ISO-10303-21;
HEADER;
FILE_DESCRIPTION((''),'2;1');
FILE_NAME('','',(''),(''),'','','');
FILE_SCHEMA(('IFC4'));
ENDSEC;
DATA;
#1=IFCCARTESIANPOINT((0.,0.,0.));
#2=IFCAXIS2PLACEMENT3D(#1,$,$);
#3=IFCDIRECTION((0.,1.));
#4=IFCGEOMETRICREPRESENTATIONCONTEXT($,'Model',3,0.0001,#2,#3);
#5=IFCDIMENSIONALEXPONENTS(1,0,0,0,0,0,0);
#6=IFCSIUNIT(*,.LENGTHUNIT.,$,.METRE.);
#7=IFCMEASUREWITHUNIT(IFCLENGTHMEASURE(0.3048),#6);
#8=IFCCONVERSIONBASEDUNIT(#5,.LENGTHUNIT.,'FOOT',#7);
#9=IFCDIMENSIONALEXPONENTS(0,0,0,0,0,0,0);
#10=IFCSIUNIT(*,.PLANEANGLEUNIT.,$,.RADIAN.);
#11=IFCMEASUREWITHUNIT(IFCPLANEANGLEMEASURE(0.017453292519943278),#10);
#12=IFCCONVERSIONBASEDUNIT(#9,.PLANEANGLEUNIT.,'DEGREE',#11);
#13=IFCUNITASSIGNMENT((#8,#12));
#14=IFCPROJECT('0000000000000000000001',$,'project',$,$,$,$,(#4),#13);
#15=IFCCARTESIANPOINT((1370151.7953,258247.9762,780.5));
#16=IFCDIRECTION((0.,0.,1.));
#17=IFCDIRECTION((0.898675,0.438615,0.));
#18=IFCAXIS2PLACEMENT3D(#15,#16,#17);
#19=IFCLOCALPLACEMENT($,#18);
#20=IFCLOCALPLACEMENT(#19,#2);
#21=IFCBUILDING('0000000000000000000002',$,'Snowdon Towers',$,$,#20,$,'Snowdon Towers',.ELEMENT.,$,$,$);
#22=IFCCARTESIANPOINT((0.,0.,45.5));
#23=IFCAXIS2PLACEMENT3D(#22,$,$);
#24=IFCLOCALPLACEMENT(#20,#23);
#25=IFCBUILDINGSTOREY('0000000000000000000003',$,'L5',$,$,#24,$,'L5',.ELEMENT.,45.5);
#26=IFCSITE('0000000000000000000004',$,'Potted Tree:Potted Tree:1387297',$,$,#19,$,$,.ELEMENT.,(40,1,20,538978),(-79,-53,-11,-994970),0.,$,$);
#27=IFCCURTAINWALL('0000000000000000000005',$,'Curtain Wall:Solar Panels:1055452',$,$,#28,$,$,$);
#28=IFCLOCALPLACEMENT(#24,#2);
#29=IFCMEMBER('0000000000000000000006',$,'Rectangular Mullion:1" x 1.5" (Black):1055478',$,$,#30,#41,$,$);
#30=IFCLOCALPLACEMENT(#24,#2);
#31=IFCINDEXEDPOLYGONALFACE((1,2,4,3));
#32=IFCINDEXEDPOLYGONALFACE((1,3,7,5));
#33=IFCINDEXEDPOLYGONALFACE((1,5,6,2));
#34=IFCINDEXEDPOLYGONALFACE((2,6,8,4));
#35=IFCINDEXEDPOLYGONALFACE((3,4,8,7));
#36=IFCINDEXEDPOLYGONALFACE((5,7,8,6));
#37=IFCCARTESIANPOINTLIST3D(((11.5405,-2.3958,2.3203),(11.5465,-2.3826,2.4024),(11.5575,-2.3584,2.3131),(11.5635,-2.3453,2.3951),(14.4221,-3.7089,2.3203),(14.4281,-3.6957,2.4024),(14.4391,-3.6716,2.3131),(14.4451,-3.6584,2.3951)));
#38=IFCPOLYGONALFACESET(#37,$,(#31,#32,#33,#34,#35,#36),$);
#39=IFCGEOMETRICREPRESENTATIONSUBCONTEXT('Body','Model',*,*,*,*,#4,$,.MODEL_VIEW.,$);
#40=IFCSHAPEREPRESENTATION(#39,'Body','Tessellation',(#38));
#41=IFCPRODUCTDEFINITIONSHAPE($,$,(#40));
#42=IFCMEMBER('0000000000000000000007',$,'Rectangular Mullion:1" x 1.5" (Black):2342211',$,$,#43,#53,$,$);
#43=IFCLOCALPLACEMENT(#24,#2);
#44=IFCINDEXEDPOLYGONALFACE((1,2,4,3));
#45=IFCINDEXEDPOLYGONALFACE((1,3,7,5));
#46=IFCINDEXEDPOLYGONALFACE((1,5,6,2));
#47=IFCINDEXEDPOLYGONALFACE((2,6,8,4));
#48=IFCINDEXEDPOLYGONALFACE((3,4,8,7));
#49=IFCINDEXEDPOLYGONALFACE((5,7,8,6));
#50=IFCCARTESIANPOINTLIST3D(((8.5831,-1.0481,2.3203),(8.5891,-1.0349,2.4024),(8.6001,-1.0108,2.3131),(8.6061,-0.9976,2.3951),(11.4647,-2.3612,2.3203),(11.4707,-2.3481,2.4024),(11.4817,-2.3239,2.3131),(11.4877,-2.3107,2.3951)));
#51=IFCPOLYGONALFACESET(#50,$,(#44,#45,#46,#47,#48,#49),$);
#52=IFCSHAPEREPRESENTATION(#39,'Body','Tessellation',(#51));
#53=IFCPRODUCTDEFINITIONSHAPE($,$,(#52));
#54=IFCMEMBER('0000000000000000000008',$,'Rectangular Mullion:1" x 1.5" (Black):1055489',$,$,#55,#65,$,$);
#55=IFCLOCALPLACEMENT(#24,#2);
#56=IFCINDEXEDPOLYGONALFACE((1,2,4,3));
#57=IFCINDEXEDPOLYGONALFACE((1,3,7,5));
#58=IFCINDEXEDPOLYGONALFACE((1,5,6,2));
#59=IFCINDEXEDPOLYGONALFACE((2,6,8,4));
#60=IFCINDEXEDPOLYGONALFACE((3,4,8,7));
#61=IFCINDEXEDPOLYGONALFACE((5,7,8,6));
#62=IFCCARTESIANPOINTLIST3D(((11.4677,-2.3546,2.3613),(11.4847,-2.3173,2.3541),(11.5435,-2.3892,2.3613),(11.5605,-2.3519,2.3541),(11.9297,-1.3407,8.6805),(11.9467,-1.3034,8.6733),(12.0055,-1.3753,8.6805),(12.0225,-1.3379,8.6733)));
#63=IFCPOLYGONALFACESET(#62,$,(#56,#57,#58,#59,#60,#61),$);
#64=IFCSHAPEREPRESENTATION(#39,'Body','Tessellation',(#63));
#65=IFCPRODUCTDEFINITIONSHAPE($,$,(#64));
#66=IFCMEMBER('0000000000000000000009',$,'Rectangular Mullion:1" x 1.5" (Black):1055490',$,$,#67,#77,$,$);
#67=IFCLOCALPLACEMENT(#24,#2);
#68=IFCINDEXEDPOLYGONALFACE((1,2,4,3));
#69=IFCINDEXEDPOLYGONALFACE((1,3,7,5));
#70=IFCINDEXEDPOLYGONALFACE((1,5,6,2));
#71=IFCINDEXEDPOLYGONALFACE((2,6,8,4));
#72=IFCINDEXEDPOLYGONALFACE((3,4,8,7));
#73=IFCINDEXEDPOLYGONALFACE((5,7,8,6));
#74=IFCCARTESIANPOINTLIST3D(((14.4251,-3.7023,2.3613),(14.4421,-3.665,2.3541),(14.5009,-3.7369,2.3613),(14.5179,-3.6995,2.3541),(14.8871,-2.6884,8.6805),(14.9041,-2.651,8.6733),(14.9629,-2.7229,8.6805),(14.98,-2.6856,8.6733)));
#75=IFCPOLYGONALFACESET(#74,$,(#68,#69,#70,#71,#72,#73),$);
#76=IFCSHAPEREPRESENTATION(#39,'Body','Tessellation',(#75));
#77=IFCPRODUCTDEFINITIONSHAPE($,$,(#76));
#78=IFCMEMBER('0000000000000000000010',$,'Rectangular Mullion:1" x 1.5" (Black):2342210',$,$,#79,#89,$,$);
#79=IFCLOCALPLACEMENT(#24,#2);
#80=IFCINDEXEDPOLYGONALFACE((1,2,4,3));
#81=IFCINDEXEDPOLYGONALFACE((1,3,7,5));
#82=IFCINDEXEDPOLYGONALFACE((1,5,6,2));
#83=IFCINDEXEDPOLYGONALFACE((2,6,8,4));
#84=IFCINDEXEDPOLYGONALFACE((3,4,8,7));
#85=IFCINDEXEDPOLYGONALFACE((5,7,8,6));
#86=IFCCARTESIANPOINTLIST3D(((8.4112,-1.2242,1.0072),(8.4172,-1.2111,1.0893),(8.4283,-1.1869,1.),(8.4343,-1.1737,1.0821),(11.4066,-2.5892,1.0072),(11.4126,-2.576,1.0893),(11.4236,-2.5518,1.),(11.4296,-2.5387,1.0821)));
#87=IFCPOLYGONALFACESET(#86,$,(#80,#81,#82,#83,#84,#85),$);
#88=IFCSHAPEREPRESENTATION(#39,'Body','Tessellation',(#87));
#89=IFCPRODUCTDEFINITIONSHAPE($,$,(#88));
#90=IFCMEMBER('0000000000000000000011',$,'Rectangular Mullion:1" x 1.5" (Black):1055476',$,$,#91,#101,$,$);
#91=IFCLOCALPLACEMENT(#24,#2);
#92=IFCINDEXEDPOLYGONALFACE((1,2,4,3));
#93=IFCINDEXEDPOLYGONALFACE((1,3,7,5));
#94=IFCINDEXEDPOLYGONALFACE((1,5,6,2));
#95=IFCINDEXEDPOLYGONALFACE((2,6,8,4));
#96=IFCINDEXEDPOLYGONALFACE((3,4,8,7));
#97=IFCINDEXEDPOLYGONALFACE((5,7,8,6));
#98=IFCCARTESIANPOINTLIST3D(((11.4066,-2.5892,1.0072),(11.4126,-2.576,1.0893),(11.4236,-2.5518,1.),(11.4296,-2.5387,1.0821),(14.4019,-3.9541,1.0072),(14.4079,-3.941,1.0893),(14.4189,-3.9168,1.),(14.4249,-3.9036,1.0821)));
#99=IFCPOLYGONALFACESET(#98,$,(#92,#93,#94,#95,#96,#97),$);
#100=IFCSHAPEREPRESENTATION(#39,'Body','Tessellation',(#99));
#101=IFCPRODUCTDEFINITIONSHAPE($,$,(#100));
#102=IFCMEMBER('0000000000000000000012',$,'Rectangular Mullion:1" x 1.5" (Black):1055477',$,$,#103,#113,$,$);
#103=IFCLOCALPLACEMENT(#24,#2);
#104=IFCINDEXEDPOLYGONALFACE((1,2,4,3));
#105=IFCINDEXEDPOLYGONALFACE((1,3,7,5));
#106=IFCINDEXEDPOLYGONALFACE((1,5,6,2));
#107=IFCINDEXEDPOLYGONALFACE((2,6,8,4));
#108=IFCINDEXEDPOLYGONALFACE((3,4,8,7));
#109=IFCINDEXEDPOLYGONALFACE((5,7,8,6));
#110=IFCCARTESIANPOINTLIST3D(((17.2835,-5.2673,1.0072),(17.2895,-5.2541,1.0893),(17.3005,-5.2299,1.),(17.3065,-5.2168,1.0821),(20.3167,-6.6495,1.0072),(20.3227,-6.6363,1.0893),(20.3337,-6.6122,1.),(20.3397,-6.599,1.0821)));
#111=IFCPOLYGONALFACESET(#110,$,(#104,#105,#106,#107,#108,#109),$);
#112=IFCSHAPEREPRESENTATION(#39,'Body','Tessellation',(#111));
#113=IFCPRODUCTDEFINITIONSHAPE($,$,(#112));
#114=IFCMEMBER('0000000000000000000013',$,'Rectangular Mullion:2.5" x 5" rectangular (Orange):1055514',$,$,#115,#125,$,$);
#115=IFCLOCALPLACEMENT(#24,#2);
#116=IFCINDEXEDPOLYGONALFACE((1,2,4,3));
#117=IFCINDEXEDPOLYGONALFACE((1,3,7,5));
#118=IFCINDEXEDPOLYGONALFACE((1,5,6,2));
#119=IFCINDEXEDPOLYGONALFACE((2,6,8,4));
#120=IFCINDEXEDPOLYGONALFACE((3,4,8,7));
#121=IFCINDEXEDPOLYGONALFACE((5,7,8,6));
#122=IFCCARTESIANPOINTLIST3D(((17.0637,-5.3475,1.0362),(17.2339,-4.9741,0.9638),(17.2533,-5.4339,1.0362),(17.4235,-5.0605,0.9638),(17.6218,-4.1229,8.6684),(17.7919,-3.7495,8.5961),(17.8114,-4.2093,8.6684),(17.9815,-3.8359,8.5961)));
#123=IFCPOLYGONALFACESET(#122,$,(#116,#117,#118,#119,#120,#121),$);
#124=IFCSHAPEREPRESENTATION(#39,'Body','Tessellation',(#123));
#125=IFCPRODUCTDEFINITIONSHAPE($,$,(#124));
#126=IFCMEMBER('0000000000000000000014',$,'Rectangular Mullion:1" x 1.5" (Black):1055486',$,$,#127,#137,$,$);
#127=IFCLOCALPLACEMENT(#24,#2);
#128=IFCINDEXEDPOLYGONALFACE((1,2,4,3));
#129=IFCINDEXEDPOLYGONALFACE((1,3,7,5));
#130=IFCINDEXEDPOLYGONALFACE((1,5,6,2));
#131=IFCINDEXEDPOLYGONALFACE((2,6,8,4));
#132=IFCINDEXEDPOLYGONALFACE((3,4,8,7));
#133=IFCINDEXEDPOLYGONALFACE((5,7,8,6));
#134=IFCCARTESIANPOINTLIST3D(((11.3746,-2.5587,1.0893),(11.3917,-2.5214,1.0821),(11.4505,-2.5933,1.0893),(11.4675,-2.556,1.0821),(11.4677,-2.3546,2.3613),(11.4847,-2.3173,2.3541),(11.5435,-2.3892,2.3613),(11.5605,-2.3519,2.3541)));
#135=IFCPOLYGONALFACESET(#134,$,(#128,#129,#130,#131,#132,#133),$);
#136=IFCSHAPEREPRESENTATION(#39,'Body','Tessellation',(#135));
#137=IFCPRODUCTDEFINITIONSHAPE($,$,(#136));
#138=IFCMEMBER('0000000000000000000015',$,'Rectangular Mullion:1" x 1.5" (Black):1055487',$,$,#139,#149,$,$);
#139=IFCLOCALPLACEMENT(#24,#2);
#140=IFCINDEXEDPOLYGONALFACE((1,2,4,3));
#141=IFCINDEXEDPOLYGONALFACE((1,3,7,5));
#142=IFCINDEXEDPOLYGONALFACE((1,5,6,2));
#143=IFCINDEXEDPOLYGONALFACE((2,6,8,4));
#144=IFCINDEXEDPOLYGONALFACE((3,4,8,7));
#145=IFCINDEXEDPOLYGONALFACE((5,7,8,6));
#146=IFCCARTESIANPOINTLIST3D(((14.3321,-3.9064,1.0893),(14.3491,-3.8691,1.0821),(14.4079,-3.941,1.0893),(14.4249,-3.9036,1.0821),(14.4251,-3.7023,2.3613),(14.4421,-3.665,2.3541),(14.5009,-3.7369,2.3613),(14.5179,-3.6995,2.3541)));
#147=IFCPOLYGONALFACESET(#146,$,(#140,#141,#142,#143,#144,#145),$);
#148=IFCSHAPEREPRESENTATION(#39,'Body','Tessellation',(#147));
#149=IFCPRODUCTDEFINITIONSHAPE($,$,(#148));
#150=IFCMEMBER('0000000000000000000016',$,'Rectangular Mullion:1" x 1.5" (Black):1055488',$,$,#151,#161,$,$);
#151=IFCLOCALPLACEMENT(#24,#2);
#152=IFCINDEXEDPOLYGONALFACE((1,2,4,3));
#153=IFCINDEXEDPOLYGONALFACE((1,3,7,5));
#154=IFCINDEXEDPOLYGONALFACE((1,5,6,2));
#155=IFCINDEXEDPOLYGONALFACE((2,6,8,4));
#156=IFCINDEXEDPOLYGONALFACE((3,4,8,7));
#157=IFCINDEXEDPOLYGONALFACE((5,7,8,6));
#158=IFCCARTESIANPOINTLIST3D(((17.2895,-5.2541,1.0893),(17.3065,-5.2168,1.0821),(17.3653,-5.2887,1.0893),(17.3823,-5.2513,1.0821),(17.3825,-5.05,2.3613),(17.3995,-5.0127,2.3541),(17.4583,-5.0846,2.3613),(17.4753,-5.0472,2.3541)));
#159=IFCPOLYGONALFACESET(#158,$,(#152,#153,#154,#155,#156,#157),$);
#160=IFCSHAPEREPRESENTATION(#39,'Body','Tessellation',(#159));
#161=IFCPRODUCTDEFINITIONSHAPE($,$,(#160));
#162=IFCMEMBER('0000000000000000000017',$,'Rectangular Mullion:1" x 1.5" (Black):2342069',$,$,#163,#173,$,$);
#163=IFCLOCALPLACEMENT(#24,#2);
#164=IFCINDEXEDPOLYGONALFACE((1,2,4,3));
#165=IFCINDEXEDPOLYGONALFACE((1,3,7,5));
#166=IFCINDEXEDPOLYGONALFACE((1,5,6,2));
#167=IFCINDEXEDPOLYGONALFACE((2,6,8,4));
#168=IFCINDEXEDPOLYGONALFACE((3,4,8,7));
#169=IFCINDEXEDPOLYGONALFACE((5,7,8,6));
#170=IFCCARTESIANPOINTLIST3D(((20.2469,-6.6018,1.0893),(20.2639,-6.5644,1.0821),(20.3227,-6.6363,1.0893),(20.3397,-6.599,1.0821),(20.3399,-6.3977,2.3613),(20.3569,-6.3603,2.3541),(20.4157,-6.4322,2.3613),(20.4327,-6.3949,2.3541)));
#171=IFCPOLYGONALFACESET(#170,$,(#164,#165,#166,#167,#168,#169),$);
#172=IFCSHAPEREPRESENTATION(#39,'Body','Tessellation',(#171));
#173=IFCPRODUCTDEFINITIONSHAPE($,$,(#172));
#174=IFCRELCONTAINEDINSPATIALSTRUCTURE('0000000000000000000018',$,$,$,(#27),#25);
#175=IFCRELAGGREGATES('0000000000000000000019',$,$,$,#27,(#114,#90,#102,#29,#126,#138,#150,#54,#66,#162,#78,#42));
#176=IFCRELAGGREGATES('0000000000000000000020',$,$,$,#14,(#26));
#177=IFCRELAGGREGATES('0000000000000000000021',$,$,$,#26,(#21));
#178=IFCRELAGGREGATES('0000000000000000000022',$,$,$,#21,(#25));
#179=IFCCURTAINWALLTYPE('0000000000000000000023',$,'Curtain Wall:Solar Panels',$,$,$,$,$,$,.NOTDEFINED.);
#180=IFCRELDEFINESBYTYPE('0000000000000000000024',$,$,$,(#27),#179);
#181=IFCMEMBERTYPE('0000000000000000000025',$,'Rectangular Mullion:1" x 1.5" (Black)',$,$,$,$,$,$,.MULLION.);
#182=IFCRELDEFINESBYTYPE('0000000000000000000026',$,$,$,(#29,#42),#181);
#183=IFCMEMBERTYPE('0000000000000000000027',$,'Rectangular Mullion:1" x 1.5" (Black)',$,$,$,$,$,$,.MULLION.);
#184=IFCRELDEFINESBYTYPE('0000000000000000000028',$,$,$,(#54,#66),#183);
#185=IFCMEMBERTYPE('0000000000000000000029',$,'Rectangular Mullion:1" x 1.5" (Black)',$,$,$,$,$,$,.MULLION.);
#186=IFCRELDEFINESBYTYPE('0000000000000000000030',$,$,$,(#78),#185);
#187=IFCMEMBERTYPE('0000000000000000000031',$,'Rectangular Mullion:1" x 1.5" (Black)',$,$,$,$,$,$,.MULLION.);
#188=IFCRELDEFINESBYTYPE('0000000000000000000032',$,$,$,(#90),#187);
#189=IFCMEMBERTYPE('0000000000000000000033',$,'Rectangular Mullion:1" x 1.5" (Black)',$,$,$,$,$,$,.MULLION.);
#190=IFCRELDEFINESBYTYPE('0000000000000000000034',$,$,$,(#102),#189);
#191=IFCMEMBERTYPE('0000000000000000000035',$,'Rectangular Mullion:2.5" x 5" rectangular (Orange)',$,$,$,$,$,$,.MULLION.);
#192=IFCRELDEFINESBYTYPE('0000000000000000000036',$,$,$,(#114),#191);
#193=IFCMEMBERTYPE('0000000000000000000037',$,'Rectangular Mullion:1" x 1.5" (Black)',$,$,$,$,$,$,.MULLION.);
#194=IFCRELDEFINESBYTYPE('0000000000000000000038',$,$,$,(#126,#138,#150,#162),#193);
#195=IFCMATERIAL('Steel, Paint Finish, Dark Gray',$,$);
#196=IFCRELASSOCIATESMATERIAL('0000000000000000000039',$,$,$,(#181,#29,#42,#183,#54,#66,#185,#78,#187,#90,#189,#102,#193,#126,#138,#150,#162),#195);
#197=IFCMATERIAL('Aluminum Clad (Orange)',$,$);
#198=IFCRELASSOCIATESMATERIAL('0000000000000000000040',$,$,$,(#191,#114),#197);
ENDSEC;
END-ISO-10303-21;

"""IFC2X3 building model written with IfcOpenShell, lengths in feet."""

from ifc_helpers import new_model, entity, si_unit, converted_unit, direction, frame, frame_2d, origin, origin_2d_with_axis, place, context, subcontext, project, spatial, rectangle, extrude, source, transform, mapped, material, type_object, type_shapes, element, aggregate, save


model = new_model("IFC2X3")

# Units and contexts
model_context = context("Model", 3, precision=0.0001, world=origin(), true_north=direction((0.0, 1.0)))
body_context = subcontext(model_context, "Body", "Model", "MODEL_VIEW")
ifc_project = project(units=[converted_unit("LENGTHUNIT", "FOOT", entity("IfcLengthMeasure", 0.3048), si_unit("LENGTHUNIT", "METRE"), dimensions=[1, 0, 0, 0, 0, 0, 0]), converted_unit("PLANEANGLEUNIT", "DEGREE", entity("IfcPlaneAngleMeasure", 0.017453292519943278), si_unit("PLANEANGLEUNIT", "RADIAN"), dimensions=[0, 0, 0, 0, 0, 0, 0])], contexts=[model_context])

# Site, building, storey
site_placement = place(None, frame((1370151.7953, 258247.9762, 780.5), z_axis=(0.0, 0.0, 1.0), x_axis=(0.898675, 0.438615, 0.0)))
site = spatial("IfcSite", under=ifc_project, at=site_placement, Name="Potted Tree:Potted Tree:1387297", CompositionType="ELEMENT", RefLatitude=(40, 1, 20, 538978), RefLongitude=(-79, -53, -11, -994970), RefElevation=0.0)
building_placement = place(site_placement, origin())
building = spatial("IfcBuilding", under=site, at=building_placement, Name="Snowdon Towers", LongName="Snowdon Towers", CompositionType="ELEMENT")
storey_placement = place(building_placement, frame((0.0, 0.0, 45.5)))
storey = spatial("IfcBuildingStorey", under=building, at=storey_placement, Name="L5", LongName="L5", CompositionType="ELEMENT", Elevation=45.5)

# Curtain wall, members
curtain_wall_type_1 = type_object("IfcCurtainWallType", Name="Curtain Wall:Solar Panels", PredefinedType="NOTDEFINED")
curtain_wall_1_placement = place(storey_placement, frame((0.0, 0.0, -45.5)))
curtain_wall_1 = element("IfcCurtainWall", 1, at=curtain_wall_1_placement, inside=storey, type_object=curtain_wall_type_1, Name="Curtain Wall:Solar Panels:1055452")
ifc_material_1 = material(Name="Steel, Paint Finish, Dark Gray")
member_type_1 = type_object("IfcMemberType", Name="Rectangular Mullion:1\" x 1.5\" (Black)", PredefinedType="MULLION", material=ifc_material_1)
shared_shape_1 = source(origin(), body_context, "Body", "SweptSolid", [
    extrude(rectangle(XDim=0.0833, YDim=0.0417, at=origin_2d_with_axis()), frame((0.0, 0.0208, -3.1667), z_axis=(0.0, 0.0, 1.0), x_axis=(-1.0, 0.0, 0.0)), (0.0, 0.0, 1.0), 3.1667),
])
type_shapes(member_type_1, [shared_shape_1])
member_1_placement = place(curtain_wall_1_placement, frame((14.4421, -3.665, 47.8541), z_axis=(0.909972, -0.414671, 0.0), x_axis=(0.072007, 0.158015, 0.984808)))
member_1 = element("IfcMember", 2, at=member_1_placement, type_object=member_type_1, material=ifc_material_1, Name="Rectangular Mullion:1\" x 1.5\" (Black):1055478", context=body_context, shape_type="MappedRepresentation", body=[
    mapped(shared_shape_1, transform((0.0, 0.0, 0.0), scale=1.0)),
])
member_2_placement = place(curtain_wall_1_placement, frame((11.4847, -2.3173, 47.8541), z_axis=(0.909972, -0.414671, 0.0), x_axis=(0.072007, 0.158015, 0.984808)))
member_2 = element("IfcMember", 3, at=member_2_placement, type_object=member_type_1, material=ifc_material_1, Name="Rectangular Mullion:1\" x 1.5\" (Black):2342211", context=body_context, shape_type="MappedRepresentation", body=[
    mapped(shared_shape_1, transform((0.0, 0.0, 0.0), scale=1.0)),
])
member_type_2 = type_object("IfcMemberType", Name="Rectangular Mullion:1\" x 1.5\" (Black)", PredefinedType="MULLION", material=ifc_material_1)
shared_shape_2 = source(origin(), body_context, "Body", "SweptSolid", [
    extrude(rectangle(XDim=0.0833, YDim=0.0417, at=origin_2d_with_axis()), frame((0.0, 0.0208, -6.4167), z_axis=(0.0, 0.0, 1.0), x_axis=(-1.0, 0.0, 0.0)), (0.0, 0.0, 1.0), 6.4167),
])
type_shapes(member_type_2, [shared_shape_2])
member_3_placement = place(curtain_wall_1_placement, frame((11.5226, -2.3346, 47.8541), z_axis=(-0.072007, -0.158015, -0.984808), x_axis=(0.909972, -0.414671, 0.0)))
member_3 = element("IfcMember", 4, at=member_3_placement, type_object=member_type_2, material=ifc_material_1, Name="Rectangular Mullion:1\" x 1.5\" (Black):1055489", context=body_context, shape_type="MappedRepresentation", body=[
    mapped(shared_shape_2, transform((0.0, 0.0, 0.0), scale=1.0)),
])
member_4_placement = place(curtain_wall_1_placement, frame((14.48, -3.6823, 47.8541), z_axis=(-0.072007, -0.158015, -0.984808), x_axis=(0.909972, -0.414671, 0.0)))
member_4 = element("IfcMember", 5, at=member_4_placement, type_object=member_type_2, material=ifc_material_1, Name="Rectangular Mullion:1\" x 1.5\" (Black):1055490", context=body_context, shape_type="MappedRepresentation", body=[
    mapped(shared_shape_2, transform((0.0, 0.0, 0.0), scale=1.0)),
])
member_type_3 = type_object("IfcMemberType", Name="Rectangular Mullion:1\" x 1.5\" (Black)", PredefinedType="MULLION", material=ifc_material_1)
shared_shape_3 = source(origin(), body_context, "Body", "SweptSolid", [
    extrude(rectangle(XDim=0.0833, YDim=0.0417, at=origin_2d_with_axis()), frame((-0.0417, 0.0208, -3.2917), z_axis=(0.0, 0.0, 1.0), x_axis=(-1.0, 0.0, 0.0)), (0.0, 0.0, 1.0), 3.2917),
])
type_shapes(member_type_3, [shared_shape_3])
member_5_placement = place(curtain_wall_1_placement, frame((8.4283, -1.1869, 46.5), z_axis=(-0.909972, 0.414671, 0.0), x_axis=(-0.072007, -0.158015, -0.984808)))
member_5 = element("IfcMember", 6, at=member_5_placement, type_object=member_type_3, material=ifc_material_1, Name="Rectangular Mullion:1\" x 1.5\" (Black):2342210", context=body_context, shape_type="MappedRepresentation", body=[
    mapped(shared_shape_3, transform((0.0, 0.0, 0.0), scale=1.0)),
])
member_type_4 = type_object("IfcMemberType", Name="Rectangular Mullion:1\" x 1.5\" (Black)", PredefinedType="MULLION", material=ifc_material_1)
shared_shape_4 = source(origin(), body_context, "Body", "SweptSolid", [
    extrude(rectangle(XDim=0.0833, YDim=0.0417, at=frame_2d((0.0, 0.0), x_axis=(1.0, 0.0))), frame((-0.0417, 0.0208, -3.2917), z_axis=(0.0, 0.0, 1.0), x_axis=(-1.0, 0.0, 0.0)), (0.0, 0.0, 1.0), 3.2917),
])
type_shapes(member_type_4, [shared_shape_4])
member_6_placement = place(curtain_wall_1_placement, frame((11.4236, -2.5518, 46.5), z_axis=(-0.909972, 0.414671, 0.0), x_axis=(-0.072007, -0.158015, -0.984808)))
member_6 = element("IfcMember", 7, at=member_6_placement, type_object=member_type_4, material=ifc_material_1, Name="Rectangular Mullion:1\" x 1.5\" (Black):1055476", context=body_context, shape_type="MappedRepresentation", body=[
    mapped(shared_shape_4, transform((0.0, 0.0, 0.0), scale=1.0)),
])
member_type_5 = type_object("IfcMemberType", Name="Rectangular Mullion:1\" x 1.5\" (Black)", PredefinedType="MULLION", material=ifc_material_1)
shared_shape_5 = source(origin(), body_context, "Body", "SweptSolid", [
    extrude(rectangle(XDim=0.0833, YDim=0.0417, at=origin_2d_with_axis()), frame((-0.0417, 0.0208, -3.3333), z_axis=(0.0, 0.0, 1.0), x_axis=(-1.0, 0.0, 0.0)), (0.0, 0.0, 1.0), 3.3333),
])
type_shapes(member_type_5, [shared_shape_5])
member_7_placement = place(curtain_wall_1_placement, frame((17.3005, -5.2299, 46.5), z_axis=(-0.909972, 0.414671, 0.0), x_axis=(-0.072007, -0.158015, -0.984808)))
member_7 = element("IfcMember", 8, at=member_7_placement, type_object=member_type_5, material=ifc_material_1, Name="Rectangular Mullion:1\" x 1.5\" (Black):1055477", context=body_context, shape_type="MappedRepresentation", body=[
    mapped(shared_shape_5, transform((0.0, 0.0, 0.0), scale=1.0)),
])
ifc_material_2 = material(Name="Aluminum Clad (Orange)")
member_type_6 = type_object("IfcMemberType", Name="Rectangular Mullion:2.5\" x 5\" rectangular (Orange)", PredefinedType="MULLION", material=ifc_material_2)
shared_shape_6 = source(origin(), body_context, "Body", "SweptSolid", [
    extrude(rectangle(XDim=0.2083, YDim=0.4167, at=frame_2d((0.0, 0.0), x_axis=(1.0, 0.0))), frame((-0.1042, 0.0, -7.75), z_axis=(0.0, 0.0, 1.0), x_axis=(-1.0, 0.0, 0.0)), (0.0, 0.0, 1.0), 7.75),
])
type_shapes(member_type_6, [shared_shape_6])
member_8_placement = place(curtain_wall_1_placement, frame((17.3384, -5.2472, 46.5), z_axis=(-0.072007, -0.158015, -0.984808), x_axis=(0.909972, -0.414671, 0.0)))
member_8 = element("IfcMember", 9, at=member_8_placement, type_object=member_type_6, material=ifc_material_2, Name="Rectangular Mullion:2.5\" x 5\" rectangular (Orange):1055514", context=body_context, shape_type="MappedRepresentation", body=[
    mapped(shared_shape_6, transform((0.0, 0.0, 0.0), scale=1.0)),
])
member_type_7 = type_object("IfcMemberType", Name="Rectangular Mullion:1\" x 1.5\" (Black)", PredefinedType="MULLION", material=ifc_material_1)
shared_shape_7 = source(origin(), body_context, "Body", "SweptSolid", [
    extrude(rectangle(XDim=0.0833, YDim=0.0417, at=origin_2d_with_axis()), frame((0.0, 0.0208, -1.2917), z_axis=(0.0, 0.0, 1.0), x_axis=(-1.0, 0.0, 0.0)), (0.0, 0.0, 1.0), 1.2917),
])
type_shapes(member_type_7, [shared_shape_7])
member_9_placement = place(curtain_wall_1_placement, frame((11.4296, -2.5387, 46.5821), z_axis=(-0.072007, -0.158015, -0.984808), x_axis=(0.909972, -0.414671, 0.0)))
member_9 = element("IfcMember", 10, at=member_9_placement, type_object=member_type_7, material=ifc_material_1, Name="Rectangular Mullion:1\" x 1.5\" (Black):1055486", context=body_context, shape_type="MappedRepresentation", body=[
    mapped(shared_shape_7, transform((0.0, 0.0, 0.0), scale=1.0)),
])
member_10_placement = place(curtain_wall_1_placement, frame((14.387, -3.8864, 46.5821), z_axis=(-0.072007, -0.158015, -0.984808), x_axis=(0.909972, -0.414671, 0.0)))
member_10 = element("IfcMember", 11, at=member_10_placement, type_object=member_type_7, material=ifc_material_1, Name="Rectangular Mullion:1\" x 1.5\" (Black):1055487", context=body_context, shape_type="MappedRepresentation", body=[
    mapped(shared_shape_7, transform((0.0, 0.0, 0.0), scale=1.0)),
])
member_11_placement = place(curtain_wall_1_placement, frame((17.3444, -5.234, 46.5821), z_axis=(-0.072007, -0.158015, -0.984808), x_axis=(0.909972, -0.414671, 0.0)))
member_11 = element("IfcMember", 12, at=member_11_placement, type_object=member_type_7, material=ifc_material_1, Name="Rectangular Mullion:1\" x 1.5\" (Black):1055488", context=body_context, shape_type="MappedRepresentation", body=[
    mapped(shared_shape_7, transform((0.0, 0.0, 0.0), scale=1.0)),
])
member_12_placement = place(curtain_wall_1_placement, frame((20.3018, -6.5817, 46.5821), z_axis=(-0.072007, -0.158015, -0.984808), x_axis=(0.909972, -0.414671, 0.0)))
member_12 = element("IfcMember", 13, at=member_12_placement, type_object=member_type_7, material=ifc_material_1, Name="Rectangular Mullion:1\" x 1.5\" (Black):2342069", context=body_context, shape_type="MappedRepresentation", body=[
    mapped(shared_shape_7, transform((0.0, 0.0, 0.0), scale=1.0)),
])

aggregate(curtain_wall_1, [member_8, member_6, member_7, member_1, member_9, member_10, member_11, member_3, member_4, member_12, member_5, member_2])

save(model, "model.ifc")
